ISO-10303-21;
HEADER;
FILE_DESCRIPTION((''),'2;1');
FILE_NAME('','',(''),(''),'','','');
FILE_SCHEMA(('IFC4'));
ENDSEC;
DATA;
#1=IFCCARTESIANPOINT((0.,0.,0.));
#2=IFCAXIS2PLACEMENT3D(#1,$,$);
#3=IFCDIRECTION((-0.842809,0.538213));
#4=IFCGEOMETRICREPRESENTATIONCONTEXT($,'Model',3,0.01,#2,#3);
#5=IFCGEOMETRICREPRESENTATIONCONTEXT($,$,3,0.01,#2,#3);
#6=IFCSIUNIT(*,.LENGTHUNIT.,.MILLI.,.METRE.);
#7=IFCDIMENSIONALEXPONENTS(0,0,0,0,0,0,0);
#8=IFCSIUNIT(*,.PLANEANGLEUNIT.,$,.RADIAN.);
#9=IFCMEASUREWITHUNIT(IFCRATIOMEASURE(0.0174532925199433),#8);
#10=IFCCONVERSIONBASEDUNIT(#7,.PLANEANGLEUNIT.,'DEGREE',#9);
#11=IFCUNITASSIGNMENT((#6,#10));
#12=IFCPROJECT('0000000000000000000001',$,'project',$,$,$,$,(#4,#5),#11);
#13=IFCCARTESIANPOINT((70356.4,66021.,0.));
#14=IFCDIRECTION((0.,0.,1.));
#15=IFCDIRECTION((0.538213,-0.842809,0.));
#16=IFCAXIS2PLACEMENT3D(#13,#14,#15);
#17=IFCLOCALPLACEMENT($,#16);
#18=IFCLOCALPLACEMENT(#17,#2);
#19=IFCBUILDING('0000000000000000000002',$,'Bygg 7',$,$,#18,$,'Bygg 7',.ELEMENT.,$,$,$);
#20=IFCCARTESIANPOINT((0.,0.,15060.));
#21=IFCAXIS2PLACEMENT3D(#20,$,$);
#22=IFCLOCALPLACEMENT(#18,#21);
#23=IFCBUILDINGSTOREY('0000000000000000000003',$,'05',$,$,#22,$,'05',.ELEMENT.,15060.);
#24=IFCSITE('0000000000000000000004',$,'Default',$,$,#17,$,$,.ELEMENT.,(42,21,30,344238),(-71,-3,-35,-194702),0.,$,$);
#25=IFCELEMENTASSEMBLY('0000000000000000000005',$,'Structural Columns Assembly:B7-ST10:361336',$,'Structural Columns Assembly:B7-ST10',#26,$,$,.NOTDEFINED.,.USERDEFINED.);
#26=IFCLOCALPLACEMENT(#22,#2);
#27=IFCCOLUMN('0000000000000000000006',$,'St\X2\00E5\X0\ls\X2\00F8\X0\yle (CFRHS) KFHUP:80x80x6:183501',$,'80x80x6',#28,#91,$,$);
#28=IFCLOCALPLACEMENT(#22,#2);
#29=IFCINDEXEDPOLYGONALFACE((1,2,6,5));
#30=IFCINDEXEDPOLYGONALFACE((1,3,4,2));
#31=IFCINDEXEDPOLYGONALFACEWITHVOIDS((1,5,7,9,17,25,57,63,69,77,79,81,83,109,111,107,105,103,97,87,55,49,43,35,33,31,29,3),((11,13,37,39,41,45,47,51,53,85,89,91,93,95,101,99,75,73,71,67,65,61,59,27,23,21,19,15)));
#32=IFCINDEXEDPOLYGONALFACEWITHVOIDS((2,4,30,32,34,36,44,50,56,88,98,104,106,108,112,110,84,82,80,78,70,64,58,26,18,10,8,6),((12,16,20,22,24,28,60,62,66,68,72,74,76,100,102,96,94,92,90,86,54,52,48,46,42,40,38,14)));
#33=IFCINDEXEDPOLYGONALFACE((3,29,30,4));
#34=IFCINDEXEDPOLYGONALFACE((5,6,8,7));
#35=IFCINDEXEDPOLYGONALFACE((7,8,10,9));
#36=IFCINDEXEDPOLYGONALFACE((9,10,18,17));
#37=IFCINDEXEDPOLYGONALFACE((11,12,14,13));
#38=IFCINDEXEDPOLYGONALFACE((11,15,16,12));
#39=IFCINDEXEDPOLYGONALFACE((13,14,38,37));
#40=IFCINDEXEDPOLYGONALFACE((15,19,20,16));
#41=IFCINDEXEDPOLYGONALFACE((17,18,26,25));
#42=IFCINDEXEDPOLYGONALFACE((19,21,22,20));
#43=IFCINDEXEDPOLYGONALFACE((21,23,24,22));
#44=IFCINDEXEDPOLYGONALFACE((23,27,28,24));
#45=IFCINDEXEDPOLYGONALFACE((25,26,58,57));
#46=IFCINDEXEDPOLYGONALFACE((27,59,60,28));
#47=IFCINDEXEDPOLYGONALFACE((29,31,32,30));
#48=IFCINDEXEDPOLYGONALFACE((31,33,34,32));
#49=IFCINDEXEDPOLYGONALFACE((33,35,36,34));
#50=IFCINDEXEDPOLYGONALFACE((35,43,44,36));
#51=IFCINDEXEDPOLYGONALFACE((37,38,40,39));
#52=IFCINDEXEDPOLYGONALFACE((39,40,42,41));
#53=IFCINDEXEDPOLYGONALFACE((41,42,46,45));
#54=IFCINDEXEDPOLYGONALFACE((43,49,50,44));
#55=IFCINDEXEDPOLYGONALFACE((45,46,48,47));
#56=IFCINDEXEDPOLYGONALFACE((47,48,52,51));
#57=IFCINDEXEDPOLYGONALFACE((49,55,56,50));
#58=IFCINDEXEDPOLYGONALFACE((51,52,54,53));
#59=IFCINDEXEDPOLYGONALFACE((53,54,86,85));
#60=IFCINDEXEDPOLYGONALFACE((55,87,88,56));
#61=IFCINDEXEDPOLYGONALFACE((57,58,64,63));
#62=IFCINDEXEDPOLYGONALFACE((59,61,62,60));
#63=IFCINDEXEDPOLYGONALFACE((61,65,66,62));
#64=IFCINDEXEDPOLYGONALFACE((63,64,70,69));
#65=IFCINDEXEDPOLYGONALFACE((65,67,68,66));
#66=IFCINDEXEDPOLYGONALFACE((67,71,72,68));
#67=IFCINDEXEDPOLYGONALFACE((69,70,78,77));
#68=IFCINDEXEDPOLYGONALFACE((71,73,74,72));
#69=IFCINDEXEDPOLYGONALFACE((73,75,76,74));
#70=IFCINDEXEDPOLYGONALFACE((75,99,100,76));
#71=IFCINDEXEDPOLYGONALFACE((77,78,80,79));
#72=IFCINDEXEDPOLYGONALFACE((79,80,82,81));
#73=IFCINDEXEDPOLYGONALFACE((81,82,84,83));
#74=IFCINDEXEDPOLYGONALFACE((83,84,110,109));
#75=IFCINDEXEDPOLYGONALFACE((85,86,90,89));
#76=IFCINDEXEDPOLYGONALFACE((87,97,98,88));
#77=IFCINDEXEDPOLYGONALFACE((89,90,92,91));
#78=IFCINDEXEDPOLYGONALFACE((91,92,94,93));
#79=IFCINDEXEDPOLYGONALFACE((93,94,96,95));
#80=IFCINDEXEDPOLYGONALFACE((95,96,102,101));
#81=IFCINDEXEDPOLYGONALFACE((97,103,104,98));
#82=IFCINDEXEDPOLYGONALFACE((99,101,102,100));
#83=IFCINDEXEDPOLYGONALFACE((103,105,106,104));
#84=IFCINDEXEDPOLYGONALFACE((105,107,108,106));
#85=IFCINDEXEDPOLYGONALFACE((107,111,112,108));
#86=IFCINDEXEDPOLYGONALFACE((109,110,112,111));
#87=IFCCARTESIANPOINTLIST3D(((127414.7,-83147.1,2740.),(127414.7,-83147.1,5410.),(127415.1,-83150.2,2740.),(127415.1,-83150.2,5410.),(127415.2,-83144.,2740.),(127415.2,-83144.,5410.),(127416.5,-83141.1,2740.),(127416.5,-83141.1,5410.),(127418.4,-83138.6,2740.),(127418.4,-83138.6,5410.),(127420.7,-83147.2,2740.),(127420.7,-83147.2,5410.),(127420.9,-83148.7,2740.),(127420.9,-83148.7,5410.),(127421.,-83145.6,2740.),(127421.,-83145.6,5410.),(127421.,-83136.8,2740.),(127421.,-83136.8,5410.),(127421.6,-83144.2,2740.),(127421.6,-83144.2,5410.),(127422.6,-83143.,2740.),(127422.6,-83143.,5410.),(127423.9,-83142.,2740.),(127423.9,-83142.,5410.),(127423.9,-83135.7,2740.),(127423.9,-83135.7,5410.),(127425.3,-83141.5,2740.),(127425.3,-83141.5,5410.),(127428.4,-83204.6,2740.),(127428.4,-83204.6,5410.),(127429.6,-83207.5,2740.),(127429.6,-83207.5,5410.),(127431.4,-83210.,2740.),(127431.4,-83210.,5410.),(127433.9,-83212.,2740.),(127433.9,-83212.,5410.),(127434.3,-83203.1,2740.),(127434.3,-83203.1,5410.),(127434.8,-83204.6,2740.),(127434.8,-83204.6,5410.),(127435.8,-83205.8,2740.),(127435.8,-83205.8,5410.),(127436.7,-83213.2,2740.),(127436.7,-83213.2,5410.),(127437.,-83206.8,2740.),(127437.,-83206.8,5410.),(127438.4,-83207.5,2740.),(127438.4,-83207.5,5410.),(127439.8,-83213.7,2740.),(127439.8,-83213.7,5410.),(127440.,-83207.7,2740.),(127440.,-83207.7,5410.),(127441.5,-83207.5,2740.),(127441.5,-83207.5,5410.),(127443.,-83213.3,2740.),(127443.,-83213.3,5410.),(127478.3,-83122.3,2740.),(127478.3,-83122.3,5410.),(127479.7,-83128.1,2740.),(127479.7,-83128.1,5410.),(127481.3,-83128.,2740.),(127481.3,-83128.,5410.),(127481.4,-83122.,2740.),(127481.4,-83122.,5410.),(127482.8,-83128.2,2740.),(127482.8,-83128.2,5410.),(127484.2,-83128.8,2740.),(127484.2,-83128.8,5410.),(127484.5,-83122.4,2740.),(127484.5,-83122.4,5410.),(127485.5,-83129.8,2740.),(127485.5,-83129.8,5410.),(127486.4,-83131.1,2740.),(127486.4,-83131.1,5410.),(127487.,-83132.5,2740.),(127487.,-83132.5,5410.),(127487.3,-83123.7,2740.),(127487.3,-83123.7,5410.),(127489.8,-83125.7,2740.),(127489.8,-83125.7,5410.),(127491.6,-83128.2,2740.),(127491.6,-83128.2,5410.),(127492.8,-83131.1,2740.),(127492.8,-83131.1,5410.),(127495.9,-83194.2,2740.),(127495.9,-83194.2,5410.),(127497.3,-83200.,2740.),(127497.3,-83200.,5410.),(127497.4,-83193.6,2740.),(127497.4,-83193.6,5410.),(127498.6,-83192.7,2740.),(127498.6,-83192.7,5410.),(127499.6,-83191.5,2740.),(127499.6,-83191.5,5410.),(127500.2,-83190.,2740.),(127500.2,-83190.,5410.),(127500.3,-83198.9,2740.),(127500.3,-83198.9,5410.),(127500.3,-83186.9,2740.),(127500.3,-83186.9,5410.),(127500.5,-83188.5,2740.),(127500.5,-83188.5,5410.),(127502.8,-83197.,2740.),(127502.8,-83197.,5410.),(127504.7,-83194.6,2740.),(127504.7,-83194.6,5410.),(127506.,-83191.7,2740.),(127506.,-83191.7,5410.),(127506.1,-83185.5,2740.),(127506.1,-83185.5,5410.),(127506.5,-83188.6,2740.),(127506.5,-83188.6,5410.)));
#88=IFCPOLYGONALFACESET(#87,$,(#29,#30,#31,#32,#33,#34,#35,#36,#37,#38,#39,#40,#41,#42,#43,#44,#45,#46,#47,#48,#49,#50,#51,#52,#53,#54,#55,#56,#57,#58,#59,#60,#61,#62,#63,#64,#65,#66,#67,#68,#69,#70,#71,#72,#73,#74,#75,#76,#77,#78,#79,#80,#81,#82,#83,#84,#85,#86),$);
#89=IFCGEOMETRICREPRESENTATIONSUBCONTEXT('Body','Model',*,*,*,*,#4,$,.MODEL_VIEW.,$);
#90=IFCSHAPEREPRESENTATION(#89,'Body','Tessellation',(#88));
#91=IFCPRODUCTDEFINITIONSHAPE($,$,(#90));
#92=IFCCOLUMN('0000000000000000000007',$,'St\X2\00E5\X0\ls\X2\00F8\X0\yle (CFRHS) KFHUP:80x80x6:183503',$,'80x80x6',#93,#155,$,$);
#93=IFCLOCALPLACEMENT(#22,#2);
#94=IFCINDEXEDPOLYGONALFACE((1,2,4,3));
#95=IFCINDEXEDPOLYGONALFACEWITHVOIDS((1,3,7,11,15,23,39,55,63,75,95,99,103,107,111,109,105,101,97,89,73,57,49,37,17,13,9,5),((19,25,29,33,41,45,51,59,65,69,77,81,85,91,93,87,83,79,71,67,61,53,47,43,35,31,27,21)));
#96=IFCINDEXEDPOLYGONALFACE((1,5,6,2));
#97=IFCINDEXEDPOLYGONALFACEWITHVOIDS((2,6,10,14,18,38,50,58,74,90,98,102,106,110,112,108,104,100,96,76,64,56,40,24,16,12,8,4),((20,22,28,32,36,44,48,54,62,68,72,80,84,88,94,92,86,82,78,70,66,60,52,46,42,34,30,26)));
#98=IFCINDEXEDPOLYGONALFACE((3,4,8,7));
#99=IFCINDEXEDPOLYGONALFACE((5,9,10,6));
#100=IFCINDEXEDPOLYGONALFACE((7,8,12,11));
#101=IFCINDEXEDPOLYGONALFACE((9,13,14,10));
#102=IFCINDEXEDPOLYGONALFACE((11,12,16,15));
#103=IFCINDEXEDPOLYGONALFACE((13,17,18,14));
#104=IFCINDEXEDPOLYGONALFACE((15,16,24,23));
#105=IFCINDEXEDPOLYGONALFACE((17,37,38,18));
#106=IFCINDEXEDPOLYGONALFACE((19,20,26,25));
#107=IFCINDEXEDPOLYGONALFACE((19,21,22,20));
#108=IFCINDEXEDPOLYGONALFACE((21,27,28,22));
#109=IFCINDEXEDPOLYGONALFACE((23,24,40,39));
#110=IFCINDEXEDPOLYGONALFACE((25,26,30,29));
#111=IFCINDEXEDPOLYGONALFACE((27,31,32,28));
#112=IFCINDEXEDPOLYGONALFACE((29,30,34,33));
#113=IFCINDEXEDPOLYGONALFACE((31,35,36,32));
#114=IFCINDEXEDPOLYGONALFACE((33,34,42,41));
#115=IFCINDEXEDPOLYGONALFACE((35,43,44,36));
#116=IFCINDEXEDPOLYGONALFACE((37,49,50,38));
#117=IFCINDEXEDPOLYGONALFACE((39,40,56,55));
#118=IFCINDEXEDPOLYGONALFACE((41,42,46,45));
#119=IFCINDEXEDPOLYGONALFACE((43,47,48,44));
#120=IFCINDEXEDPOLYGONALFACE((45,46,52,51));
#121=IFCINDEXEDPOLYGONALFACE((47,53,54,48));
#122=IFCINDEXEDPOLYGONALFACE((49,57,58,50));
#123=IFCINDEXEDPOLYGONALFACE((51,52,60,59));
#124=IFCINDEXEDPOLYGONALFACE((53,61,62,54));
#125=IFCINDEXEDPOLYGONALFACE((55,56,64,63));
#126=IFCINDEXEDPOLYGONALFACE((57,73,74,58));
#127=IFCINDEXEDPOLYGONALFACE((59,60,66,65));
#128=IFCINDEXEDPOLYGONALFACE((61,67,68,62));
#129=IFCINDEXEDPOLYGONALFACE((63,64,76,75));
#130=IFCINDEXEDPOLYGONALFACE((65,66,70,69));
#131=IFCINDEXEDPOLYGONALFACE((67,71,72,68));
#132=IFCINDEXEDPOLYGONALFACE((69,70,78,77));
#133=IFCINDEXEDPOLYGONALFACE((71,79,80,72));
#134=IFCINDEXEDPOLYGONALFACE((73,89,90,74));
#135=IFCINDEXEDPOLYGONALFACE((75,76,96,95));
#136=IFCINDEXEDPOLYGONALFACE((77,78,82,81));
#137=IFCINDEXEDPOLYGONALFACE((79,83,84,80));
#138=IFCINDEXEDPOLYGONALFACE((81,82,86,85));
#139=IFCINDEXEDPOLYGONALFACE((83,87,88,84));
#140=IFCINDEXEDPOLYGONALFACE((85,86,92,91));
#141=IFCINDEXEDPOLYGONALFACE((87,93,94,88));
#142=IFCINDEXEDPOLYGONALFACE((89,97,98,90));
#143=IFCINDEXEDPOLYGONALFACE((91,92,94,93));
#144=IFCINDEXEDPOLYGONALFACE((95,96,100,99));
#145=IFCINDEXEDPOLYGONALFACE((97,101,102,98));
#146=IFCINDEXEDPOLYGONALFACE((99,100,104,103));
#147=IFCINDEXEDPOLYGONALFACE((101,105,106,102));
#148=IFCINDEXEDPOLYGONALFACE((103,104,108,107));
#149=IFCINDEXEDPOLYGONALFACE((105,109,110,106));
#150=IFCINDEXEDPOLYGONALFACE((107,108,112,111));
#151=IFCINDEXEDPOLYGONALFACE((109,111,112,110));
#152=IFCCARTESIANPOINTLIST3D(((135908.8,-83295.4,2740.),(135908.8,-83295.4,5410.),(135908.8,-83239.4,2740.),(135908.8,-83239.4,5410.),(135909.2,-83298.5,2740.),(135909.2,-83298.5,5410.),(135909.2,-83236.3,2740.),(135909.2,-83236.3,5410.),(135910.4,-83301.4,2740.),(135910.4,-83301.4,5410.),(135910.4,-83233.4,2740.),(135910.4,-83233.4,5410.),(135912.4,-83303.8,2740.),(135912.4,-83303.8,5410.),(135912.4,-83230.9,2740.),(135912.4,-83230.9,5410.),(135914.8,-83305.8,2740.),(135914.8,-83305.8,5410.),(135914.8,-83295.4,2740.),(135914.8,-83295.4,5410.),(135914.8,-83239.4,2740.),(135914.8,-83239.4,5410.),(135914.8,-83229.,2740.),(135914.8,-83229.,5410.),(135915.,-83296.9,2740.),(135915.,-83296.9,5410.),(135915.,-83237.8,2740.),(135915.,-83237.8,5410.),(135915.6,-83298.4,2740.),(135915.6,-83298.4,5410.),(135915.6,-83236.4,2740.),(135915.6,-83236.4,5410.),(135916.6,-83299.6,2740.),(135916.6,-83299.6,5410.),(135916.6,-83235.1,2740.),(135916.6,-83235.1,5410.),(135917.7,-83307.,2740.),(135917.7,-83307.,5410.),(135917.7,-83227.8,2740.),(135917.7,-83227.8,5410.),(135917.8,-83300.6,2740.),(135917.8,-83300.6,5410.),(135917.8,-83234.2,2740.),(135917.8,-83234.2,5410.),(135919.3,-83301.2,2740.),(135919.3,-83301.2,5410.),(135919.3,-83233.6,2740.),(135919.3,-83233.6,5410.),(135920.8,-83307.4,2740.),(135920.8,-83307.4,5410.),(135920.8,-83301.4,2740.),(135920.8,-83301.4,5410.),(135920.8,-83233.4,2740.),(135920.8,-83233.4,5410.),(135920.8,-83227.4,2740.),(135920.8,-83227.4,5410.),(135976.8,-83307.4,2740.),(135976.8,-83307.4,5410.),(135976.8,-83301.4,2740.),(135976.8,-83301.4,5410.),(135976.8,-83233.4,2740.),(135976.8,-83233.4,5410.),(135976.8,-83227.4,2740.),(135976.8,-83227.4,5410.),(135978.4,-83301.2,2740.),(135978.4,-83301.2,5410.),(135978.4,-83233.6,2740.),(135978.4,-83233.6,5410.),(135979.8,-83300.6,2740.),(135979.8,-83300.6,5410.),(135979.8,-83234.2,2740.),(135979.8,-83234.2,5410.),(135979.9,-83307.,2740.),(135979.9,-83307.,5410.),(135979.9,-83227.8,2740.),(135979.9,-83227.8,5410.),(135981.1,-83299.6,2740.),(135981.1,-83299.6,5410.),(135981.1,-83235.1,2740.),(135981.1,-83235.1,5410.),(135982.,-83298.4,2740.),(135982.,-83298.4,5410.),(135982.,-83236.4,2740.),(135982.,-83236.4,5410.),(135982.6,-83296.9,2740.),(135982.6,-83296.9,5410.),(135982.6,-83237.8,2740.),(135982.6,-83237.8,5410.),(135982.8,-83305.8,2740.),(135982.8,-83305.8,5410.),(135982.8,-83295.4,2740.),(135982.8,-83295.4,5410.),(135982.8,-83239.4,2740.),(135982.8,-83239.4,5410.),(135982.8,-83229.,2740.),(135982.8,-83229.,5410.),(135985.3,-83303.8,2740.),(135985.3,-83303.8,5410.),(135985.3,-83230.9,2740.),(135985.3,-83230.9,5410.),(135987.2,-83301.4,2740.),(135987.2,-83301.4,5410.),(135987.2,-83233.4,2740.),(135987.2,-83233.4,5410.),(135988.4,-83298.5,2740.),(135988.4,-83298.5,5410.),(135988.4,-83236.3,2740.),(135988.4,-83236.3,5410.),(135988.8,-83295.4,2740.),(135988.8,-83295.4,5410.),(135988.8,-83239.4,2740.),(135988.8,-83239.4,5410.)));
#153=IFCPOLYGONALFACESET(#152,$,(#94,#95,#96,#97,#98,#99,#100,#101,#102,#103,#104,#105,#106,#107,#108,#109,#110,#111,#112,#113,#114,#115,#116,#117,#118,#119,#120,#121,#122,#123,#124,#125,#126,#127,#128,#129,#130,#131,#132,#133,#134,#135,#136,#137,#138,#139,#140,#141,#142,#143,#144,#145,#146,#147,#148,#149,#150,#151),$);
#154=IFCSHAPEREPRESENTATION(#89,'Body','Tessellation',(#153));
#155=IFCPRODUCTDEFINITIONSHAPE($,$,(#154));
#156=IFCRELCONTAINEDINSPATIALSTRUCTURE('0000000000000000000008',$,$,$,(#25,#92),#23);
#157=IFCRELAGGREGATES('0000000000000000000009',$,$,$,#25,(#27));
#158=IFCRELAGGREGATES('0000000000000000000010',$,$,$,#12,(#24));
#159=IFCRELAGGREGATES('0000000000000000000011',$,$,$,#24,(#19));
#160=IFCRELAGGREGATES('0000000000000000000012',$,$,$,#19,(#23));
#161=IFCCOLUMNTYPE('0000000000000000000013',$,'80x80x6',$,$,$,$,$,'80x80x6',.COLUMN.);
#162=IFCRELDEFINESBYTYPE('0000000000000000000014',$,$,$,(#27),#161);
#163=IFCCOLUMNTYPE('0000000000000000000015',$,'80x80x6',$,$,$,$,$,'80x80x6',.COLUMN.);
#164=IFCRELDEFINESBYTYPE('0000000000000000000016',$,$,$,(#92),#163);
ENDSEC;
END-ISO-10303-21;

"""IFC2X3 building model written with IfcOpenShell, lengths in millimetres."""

from ifc_helpers import new_model, entity, si_unit, converted_unit, direction, frame, frame_2d, origin, place, context, subcontext, project, spatial, polyline, circle_curve, parameter, trimmed, segment, composite_curve, outline, extrude, source, transform, mapped, type_object, type_shapes, element, aggregate, save


model = new_model("IFC2X3")

# Units and contexts
model_context = context("Model", 3, precision=0.01, world=origin(), true_north=direction((-0.842809, 0.538213)))
context_of_model = context(None, 3, precision=0.01, world=origin(), true_north=direction((-0.842809, 0.538213)))
body_context = subcontext(model_context, "Body", "Model", "MODEL_VIEW")
ifc_project = project(units=[si_unit("LENGTHUNIT", "METRE", prefix="MILLI"), converted_unit("PLANEANGLEUNIT", "DEGREE", entity("IfcRatioMeasure", 0.0174532925199433), si_unit("PLANEANGLEUNIT", "RADIAN"), dimensions=[0, 0, 0, 0, 0, 0, 0])], contexts=[model_context, context_of_model])

# Site, building, storey
site_placement = place(None, frame((70356.4, 66021.0, 0.0), z_axis=(0.0, 0.0, 1.0), x_axis=(0.538213, -0.842809, 0.0)))
site = spatial("IfcSite", under=ifc_project, at=site_placement, Name="Default", CompositionType="ELEMENT", RefLatitude=(42, 21, 30, 344238), RefLongitude=(-71, -3, -35, -194702), RefElevation=0.0)
building_placement = place(site_placement, origin())
building = spatial("IfcBuilding", under=site, at=building_placement, Name="Bygg 7", LongName="Bygg 7", CompositionType="ELEMENT")
storey_placement = place(building_placement, frame((0.0, 0.0, 15060.0)))
storey = spatial("IfcBuildingStorey", under=building, at=storey_placement, Name="05", LongName="05", CompositionType="ELEMENT", Elevation=15060.0)

# Element assembly, column
assembly_1_placement = place(storey_placement, origin())
assembly_1 = element("IfcElementAssembly", 1, at=assembly_1_placement, inside=storey, Name="Structural Columns Assembly:B7-ST10:361336", ObjectType="Structural Columns Assembly:B7-ST10", AssemblyPlace="NOTDEFINED", PredefinedType="USERDEFINED")
column_type_1 = type_object("IfcColumnType", Name="80x80x6", ElementType="80x80x6", PredefinedType="COLUMN")
shared_shape_1 = source(origin(), body_context, "Body", "SweptSolid", [
    extrude(outline(composite_curve([segment(trimmed(circle_curve(frame_2d((-28.0, 28.0), x_axis=(1.0, 0.0)), 12.0), [parameter(90.0)], [parameter(180.0)], True, "PARAMETER"), True, "CONTINUOUS"), segment(polyline([(-40.0, 28.0), (-40.0, -28.0)]), True, "CONTINUOUS"), segment(trimmed(circle_curve(frame_2d((-28.0, -28.0), x_axis=(1.0, 0.0)), 12.0), [parameter(180.0)], [parameter(270.0)], True, "PARAMETER"), True, "CONTINUOUS"), segment(polyline([(-28.0, -40.0), (28.0, -40.0)]), True, "CONTINUOUS"), segment(trimmed(circle_curve(frame_2d((28.0, -28.0), x_axis=(1.0, 0.0)), 12.0), [parameter(270.0)], [parameter(0.0)], True, "PARAMETER"), True, "CONTINUOUS"), segment(polyline([(40.0, -28.0), (40.0, 28.0)]), True, "CONTINUOUS"), segment(trimmed(circle_curve(frame_2d((28.0, 28.0), x_axis=(1.0, 0.0)), 12.0), [parameter(0.0)], [parameter(90.0)], True, "PARAMETER"), True, "CONTINUOUS"), segment(polyline([(28.0, 40.0), (-28.0, 40.0)]), True, "CONTINUOUS")], self_intersect=False), holes=[composite_curve([segment(polyline([(-28.0, 34.0), (28.0, 34.0)]), True, "CONTINUOUS"), segment(trimmed(circle_curve(frame_2d((28.0, 28.0), x_axis=(1.0, 0.0)), 6.0), [parameter(360.0)], [parameter(90.0)], True, "PARAMETER"), False, "CONTINUOUS"), segment(polyline([(34.0, 28.0), (34.0, -28.0)]), True, "CONTINUOUS"), segment(trimmed(circle_curve(frame_2d((28.0, -28.0), x_axis=(1.0, 0.0)), 6.0), [parameter(270.0)], [parameter(360.0)], True, "PARAMETER"), False, "CONTINUOUS"), segment(polyline([(28.0, -34.0), (-28.0, -34.0)]), True, "CONTINUOUS"), segment(trimmed(circle_curve(frame_2d((-28.0, -28.0), x_axis=(1.0, 0.0)), 6.0), [parameter(180.0)], [parameter(270.0)], True, "PARAMETER"), False, "CONTINUOUS"), segment(polyline([(-34.0, -28.0), (-34.0, 28.0)]), True, "CONTINUOUS"), segment(trimmed(circle_curve(frame_2d((-28.0, 28.0), x_axis=(1.0, 0.0)), 6.0), [parameter(90.0)], [parameter(180.0)], True, "PARAMETER"), False, "CONTINUOUS")], self_intersect=False)]), frame((47.5, 47.5, 0.0), z_axis=(0.0, 0.0, 1.0), x_axis=(-0.971172, -0.238381, 0.0)), (0.0, 0.0, 1.0), 2670.0),
])
type_shapes(column_type_1, [shared_shape_1])
column_1_placement = place(assembly_1_placement, frame((127413.1, -83215.3, 2740.0)))
column_1 = element("IfcColumn", 2, at=column_1_placement, type_object=column_type_1, Name="Stålsøyle (CFRHS) KFHUP:80x80x6:183501", ObjectType="80x80x6", context=body_context, shape_type="MappedRepresentation", body=[
    mapped(shared_shape_1, transform((0.0, 0.0, 0.0), scale=1.0)),
])
aggregate(assembly_1, [column_1])

# Column
column_type_2 = type_object("IfcColumnType", Name="80x80x6", ElementType="80x80x6", PredefinedType="COLUMN")
shared_shape_2 = source(origin(), body_context, "Body", "SweptSolid", [
    extrude(outline(composite_curve([segment(trimmed(circle_curve(frame_2d((-28.0, 28.0), x_axis=(1.0, 0.0)), 12.0), [parameter(90.0)], [parameter(180.0)], True, "PARAMETER"), True, "CONTINUOUS"), segment(polyline([(-40.0, 28.0), (-40.0, -28.0)]), True, "CONTINUOUS"), segment(trimmed(circle_curve(frame_2d((-28.0, -28.0), x_axis=(1.0, 0.0)), 12.0), [parameter(180.0)], [parameter(270.0)], True, "PARAMETER"), True, "CONTINUOUS"), segment(polyline([(-28.0, -40.0), (28.0, -40.0)]), True, "CONTINUOUS"), segment(trimmed(circle_curve(frame_2d((28.0, -28.0), x_axis=(1.0, 0.0)), 12.0), [parameter(270.0)], [parameter(0.0)], True, "PARAMETER"), True, "CONTINUOUS"), segment(polyline([(40.0, -28.0), (40.0, 28.0)]), True, "CONTINUOUS"), segment(trimmed(circle_curve(frame_2d((28.0, 28.0), x_axis=(1.0, 0.0)), 12.0), [parameter(0.0)], [parameter(90.0)], True, "PARAMETER"), True, "CONTINUOUS"), segment(polyline([(28.0, 40.0), (-28.0, 40.0)]), True, "CONTINUOUS")], self_intersect=False), holes=[composite_curve([segment(polyline([(-28.0, 34.0), (28.0, 34.0)]), True, "CONTINUOUS"), segment(trimmed(circle_curve(frame_2d((28.0, 28.0), x_axis=(1.0, 0.0)), 6.0), [parameter(360.0)], [parameter(90.0)], True, "PARAMETER"), False, "CONTINUOUS"), segment(polyline([(34.0, 28.0), (34.0, -28.0)]), True, "CONTINUOUS"), segment(trimmed(circle_curve(frame_2d((28.0, -28.0), x_axis=(1.0, 0.0)), 6.0), [parameter(270.0)], [parameter(360.0)], True, "PARAMETER"), False, "CONTINUOUS"), segment(polyline([(28.0, -34.0), (-28.0, -34.0)]), True, "CONTINUOUS"), segment(trimmed(circle_curve(frame_2d((-28.0, -28.0), x_axis=(1.0, 0.0)), 6.0), [parameter(180.0)], [parameter(270.0)], True, "PARAMETER"), False, "CONTINUOUS"), segment(polyline([(-34.0, -28.0), (-34.0, 28.0)]), True, "CONTINUOUS"), segment(trimmed(circle_curve(frame_2d((-28.0, 28.0), x_axis=(1.0, 0.0)), 6.0), [parameter(90.0)], [parameter(180.0)], True, "PARAMETER"), False, "CONTINUOUS")], self_intersect=False)]), frame((41.6, 41.6, 0.0), z_axis=(0.0, 0.0, 1.0), x_axis=(0.0, -1.0, 0.0)), (0.0, 0.0, 1.0), 2670.0),
])
type_shapes(column_type_2, [shared_shape_2])
column_2_placement = place(storey_placement, frame((135907.2, -83309.0, 2740.0)))
element("IfcColumn", 3, at=column_2_placement, inside=storey, type_object=column_type_2, Name="Stålsøyle (CFRHS) KFHUP:80x80x6:183503", ObjectType="80x80x6", context=body_context, shape_type="MappedRepresentation", body=[
    mapped(shared_shape_2, transform((0.0, 0.0, 0.0), scale=1.0)),
])

save(model, "model.ifc")
